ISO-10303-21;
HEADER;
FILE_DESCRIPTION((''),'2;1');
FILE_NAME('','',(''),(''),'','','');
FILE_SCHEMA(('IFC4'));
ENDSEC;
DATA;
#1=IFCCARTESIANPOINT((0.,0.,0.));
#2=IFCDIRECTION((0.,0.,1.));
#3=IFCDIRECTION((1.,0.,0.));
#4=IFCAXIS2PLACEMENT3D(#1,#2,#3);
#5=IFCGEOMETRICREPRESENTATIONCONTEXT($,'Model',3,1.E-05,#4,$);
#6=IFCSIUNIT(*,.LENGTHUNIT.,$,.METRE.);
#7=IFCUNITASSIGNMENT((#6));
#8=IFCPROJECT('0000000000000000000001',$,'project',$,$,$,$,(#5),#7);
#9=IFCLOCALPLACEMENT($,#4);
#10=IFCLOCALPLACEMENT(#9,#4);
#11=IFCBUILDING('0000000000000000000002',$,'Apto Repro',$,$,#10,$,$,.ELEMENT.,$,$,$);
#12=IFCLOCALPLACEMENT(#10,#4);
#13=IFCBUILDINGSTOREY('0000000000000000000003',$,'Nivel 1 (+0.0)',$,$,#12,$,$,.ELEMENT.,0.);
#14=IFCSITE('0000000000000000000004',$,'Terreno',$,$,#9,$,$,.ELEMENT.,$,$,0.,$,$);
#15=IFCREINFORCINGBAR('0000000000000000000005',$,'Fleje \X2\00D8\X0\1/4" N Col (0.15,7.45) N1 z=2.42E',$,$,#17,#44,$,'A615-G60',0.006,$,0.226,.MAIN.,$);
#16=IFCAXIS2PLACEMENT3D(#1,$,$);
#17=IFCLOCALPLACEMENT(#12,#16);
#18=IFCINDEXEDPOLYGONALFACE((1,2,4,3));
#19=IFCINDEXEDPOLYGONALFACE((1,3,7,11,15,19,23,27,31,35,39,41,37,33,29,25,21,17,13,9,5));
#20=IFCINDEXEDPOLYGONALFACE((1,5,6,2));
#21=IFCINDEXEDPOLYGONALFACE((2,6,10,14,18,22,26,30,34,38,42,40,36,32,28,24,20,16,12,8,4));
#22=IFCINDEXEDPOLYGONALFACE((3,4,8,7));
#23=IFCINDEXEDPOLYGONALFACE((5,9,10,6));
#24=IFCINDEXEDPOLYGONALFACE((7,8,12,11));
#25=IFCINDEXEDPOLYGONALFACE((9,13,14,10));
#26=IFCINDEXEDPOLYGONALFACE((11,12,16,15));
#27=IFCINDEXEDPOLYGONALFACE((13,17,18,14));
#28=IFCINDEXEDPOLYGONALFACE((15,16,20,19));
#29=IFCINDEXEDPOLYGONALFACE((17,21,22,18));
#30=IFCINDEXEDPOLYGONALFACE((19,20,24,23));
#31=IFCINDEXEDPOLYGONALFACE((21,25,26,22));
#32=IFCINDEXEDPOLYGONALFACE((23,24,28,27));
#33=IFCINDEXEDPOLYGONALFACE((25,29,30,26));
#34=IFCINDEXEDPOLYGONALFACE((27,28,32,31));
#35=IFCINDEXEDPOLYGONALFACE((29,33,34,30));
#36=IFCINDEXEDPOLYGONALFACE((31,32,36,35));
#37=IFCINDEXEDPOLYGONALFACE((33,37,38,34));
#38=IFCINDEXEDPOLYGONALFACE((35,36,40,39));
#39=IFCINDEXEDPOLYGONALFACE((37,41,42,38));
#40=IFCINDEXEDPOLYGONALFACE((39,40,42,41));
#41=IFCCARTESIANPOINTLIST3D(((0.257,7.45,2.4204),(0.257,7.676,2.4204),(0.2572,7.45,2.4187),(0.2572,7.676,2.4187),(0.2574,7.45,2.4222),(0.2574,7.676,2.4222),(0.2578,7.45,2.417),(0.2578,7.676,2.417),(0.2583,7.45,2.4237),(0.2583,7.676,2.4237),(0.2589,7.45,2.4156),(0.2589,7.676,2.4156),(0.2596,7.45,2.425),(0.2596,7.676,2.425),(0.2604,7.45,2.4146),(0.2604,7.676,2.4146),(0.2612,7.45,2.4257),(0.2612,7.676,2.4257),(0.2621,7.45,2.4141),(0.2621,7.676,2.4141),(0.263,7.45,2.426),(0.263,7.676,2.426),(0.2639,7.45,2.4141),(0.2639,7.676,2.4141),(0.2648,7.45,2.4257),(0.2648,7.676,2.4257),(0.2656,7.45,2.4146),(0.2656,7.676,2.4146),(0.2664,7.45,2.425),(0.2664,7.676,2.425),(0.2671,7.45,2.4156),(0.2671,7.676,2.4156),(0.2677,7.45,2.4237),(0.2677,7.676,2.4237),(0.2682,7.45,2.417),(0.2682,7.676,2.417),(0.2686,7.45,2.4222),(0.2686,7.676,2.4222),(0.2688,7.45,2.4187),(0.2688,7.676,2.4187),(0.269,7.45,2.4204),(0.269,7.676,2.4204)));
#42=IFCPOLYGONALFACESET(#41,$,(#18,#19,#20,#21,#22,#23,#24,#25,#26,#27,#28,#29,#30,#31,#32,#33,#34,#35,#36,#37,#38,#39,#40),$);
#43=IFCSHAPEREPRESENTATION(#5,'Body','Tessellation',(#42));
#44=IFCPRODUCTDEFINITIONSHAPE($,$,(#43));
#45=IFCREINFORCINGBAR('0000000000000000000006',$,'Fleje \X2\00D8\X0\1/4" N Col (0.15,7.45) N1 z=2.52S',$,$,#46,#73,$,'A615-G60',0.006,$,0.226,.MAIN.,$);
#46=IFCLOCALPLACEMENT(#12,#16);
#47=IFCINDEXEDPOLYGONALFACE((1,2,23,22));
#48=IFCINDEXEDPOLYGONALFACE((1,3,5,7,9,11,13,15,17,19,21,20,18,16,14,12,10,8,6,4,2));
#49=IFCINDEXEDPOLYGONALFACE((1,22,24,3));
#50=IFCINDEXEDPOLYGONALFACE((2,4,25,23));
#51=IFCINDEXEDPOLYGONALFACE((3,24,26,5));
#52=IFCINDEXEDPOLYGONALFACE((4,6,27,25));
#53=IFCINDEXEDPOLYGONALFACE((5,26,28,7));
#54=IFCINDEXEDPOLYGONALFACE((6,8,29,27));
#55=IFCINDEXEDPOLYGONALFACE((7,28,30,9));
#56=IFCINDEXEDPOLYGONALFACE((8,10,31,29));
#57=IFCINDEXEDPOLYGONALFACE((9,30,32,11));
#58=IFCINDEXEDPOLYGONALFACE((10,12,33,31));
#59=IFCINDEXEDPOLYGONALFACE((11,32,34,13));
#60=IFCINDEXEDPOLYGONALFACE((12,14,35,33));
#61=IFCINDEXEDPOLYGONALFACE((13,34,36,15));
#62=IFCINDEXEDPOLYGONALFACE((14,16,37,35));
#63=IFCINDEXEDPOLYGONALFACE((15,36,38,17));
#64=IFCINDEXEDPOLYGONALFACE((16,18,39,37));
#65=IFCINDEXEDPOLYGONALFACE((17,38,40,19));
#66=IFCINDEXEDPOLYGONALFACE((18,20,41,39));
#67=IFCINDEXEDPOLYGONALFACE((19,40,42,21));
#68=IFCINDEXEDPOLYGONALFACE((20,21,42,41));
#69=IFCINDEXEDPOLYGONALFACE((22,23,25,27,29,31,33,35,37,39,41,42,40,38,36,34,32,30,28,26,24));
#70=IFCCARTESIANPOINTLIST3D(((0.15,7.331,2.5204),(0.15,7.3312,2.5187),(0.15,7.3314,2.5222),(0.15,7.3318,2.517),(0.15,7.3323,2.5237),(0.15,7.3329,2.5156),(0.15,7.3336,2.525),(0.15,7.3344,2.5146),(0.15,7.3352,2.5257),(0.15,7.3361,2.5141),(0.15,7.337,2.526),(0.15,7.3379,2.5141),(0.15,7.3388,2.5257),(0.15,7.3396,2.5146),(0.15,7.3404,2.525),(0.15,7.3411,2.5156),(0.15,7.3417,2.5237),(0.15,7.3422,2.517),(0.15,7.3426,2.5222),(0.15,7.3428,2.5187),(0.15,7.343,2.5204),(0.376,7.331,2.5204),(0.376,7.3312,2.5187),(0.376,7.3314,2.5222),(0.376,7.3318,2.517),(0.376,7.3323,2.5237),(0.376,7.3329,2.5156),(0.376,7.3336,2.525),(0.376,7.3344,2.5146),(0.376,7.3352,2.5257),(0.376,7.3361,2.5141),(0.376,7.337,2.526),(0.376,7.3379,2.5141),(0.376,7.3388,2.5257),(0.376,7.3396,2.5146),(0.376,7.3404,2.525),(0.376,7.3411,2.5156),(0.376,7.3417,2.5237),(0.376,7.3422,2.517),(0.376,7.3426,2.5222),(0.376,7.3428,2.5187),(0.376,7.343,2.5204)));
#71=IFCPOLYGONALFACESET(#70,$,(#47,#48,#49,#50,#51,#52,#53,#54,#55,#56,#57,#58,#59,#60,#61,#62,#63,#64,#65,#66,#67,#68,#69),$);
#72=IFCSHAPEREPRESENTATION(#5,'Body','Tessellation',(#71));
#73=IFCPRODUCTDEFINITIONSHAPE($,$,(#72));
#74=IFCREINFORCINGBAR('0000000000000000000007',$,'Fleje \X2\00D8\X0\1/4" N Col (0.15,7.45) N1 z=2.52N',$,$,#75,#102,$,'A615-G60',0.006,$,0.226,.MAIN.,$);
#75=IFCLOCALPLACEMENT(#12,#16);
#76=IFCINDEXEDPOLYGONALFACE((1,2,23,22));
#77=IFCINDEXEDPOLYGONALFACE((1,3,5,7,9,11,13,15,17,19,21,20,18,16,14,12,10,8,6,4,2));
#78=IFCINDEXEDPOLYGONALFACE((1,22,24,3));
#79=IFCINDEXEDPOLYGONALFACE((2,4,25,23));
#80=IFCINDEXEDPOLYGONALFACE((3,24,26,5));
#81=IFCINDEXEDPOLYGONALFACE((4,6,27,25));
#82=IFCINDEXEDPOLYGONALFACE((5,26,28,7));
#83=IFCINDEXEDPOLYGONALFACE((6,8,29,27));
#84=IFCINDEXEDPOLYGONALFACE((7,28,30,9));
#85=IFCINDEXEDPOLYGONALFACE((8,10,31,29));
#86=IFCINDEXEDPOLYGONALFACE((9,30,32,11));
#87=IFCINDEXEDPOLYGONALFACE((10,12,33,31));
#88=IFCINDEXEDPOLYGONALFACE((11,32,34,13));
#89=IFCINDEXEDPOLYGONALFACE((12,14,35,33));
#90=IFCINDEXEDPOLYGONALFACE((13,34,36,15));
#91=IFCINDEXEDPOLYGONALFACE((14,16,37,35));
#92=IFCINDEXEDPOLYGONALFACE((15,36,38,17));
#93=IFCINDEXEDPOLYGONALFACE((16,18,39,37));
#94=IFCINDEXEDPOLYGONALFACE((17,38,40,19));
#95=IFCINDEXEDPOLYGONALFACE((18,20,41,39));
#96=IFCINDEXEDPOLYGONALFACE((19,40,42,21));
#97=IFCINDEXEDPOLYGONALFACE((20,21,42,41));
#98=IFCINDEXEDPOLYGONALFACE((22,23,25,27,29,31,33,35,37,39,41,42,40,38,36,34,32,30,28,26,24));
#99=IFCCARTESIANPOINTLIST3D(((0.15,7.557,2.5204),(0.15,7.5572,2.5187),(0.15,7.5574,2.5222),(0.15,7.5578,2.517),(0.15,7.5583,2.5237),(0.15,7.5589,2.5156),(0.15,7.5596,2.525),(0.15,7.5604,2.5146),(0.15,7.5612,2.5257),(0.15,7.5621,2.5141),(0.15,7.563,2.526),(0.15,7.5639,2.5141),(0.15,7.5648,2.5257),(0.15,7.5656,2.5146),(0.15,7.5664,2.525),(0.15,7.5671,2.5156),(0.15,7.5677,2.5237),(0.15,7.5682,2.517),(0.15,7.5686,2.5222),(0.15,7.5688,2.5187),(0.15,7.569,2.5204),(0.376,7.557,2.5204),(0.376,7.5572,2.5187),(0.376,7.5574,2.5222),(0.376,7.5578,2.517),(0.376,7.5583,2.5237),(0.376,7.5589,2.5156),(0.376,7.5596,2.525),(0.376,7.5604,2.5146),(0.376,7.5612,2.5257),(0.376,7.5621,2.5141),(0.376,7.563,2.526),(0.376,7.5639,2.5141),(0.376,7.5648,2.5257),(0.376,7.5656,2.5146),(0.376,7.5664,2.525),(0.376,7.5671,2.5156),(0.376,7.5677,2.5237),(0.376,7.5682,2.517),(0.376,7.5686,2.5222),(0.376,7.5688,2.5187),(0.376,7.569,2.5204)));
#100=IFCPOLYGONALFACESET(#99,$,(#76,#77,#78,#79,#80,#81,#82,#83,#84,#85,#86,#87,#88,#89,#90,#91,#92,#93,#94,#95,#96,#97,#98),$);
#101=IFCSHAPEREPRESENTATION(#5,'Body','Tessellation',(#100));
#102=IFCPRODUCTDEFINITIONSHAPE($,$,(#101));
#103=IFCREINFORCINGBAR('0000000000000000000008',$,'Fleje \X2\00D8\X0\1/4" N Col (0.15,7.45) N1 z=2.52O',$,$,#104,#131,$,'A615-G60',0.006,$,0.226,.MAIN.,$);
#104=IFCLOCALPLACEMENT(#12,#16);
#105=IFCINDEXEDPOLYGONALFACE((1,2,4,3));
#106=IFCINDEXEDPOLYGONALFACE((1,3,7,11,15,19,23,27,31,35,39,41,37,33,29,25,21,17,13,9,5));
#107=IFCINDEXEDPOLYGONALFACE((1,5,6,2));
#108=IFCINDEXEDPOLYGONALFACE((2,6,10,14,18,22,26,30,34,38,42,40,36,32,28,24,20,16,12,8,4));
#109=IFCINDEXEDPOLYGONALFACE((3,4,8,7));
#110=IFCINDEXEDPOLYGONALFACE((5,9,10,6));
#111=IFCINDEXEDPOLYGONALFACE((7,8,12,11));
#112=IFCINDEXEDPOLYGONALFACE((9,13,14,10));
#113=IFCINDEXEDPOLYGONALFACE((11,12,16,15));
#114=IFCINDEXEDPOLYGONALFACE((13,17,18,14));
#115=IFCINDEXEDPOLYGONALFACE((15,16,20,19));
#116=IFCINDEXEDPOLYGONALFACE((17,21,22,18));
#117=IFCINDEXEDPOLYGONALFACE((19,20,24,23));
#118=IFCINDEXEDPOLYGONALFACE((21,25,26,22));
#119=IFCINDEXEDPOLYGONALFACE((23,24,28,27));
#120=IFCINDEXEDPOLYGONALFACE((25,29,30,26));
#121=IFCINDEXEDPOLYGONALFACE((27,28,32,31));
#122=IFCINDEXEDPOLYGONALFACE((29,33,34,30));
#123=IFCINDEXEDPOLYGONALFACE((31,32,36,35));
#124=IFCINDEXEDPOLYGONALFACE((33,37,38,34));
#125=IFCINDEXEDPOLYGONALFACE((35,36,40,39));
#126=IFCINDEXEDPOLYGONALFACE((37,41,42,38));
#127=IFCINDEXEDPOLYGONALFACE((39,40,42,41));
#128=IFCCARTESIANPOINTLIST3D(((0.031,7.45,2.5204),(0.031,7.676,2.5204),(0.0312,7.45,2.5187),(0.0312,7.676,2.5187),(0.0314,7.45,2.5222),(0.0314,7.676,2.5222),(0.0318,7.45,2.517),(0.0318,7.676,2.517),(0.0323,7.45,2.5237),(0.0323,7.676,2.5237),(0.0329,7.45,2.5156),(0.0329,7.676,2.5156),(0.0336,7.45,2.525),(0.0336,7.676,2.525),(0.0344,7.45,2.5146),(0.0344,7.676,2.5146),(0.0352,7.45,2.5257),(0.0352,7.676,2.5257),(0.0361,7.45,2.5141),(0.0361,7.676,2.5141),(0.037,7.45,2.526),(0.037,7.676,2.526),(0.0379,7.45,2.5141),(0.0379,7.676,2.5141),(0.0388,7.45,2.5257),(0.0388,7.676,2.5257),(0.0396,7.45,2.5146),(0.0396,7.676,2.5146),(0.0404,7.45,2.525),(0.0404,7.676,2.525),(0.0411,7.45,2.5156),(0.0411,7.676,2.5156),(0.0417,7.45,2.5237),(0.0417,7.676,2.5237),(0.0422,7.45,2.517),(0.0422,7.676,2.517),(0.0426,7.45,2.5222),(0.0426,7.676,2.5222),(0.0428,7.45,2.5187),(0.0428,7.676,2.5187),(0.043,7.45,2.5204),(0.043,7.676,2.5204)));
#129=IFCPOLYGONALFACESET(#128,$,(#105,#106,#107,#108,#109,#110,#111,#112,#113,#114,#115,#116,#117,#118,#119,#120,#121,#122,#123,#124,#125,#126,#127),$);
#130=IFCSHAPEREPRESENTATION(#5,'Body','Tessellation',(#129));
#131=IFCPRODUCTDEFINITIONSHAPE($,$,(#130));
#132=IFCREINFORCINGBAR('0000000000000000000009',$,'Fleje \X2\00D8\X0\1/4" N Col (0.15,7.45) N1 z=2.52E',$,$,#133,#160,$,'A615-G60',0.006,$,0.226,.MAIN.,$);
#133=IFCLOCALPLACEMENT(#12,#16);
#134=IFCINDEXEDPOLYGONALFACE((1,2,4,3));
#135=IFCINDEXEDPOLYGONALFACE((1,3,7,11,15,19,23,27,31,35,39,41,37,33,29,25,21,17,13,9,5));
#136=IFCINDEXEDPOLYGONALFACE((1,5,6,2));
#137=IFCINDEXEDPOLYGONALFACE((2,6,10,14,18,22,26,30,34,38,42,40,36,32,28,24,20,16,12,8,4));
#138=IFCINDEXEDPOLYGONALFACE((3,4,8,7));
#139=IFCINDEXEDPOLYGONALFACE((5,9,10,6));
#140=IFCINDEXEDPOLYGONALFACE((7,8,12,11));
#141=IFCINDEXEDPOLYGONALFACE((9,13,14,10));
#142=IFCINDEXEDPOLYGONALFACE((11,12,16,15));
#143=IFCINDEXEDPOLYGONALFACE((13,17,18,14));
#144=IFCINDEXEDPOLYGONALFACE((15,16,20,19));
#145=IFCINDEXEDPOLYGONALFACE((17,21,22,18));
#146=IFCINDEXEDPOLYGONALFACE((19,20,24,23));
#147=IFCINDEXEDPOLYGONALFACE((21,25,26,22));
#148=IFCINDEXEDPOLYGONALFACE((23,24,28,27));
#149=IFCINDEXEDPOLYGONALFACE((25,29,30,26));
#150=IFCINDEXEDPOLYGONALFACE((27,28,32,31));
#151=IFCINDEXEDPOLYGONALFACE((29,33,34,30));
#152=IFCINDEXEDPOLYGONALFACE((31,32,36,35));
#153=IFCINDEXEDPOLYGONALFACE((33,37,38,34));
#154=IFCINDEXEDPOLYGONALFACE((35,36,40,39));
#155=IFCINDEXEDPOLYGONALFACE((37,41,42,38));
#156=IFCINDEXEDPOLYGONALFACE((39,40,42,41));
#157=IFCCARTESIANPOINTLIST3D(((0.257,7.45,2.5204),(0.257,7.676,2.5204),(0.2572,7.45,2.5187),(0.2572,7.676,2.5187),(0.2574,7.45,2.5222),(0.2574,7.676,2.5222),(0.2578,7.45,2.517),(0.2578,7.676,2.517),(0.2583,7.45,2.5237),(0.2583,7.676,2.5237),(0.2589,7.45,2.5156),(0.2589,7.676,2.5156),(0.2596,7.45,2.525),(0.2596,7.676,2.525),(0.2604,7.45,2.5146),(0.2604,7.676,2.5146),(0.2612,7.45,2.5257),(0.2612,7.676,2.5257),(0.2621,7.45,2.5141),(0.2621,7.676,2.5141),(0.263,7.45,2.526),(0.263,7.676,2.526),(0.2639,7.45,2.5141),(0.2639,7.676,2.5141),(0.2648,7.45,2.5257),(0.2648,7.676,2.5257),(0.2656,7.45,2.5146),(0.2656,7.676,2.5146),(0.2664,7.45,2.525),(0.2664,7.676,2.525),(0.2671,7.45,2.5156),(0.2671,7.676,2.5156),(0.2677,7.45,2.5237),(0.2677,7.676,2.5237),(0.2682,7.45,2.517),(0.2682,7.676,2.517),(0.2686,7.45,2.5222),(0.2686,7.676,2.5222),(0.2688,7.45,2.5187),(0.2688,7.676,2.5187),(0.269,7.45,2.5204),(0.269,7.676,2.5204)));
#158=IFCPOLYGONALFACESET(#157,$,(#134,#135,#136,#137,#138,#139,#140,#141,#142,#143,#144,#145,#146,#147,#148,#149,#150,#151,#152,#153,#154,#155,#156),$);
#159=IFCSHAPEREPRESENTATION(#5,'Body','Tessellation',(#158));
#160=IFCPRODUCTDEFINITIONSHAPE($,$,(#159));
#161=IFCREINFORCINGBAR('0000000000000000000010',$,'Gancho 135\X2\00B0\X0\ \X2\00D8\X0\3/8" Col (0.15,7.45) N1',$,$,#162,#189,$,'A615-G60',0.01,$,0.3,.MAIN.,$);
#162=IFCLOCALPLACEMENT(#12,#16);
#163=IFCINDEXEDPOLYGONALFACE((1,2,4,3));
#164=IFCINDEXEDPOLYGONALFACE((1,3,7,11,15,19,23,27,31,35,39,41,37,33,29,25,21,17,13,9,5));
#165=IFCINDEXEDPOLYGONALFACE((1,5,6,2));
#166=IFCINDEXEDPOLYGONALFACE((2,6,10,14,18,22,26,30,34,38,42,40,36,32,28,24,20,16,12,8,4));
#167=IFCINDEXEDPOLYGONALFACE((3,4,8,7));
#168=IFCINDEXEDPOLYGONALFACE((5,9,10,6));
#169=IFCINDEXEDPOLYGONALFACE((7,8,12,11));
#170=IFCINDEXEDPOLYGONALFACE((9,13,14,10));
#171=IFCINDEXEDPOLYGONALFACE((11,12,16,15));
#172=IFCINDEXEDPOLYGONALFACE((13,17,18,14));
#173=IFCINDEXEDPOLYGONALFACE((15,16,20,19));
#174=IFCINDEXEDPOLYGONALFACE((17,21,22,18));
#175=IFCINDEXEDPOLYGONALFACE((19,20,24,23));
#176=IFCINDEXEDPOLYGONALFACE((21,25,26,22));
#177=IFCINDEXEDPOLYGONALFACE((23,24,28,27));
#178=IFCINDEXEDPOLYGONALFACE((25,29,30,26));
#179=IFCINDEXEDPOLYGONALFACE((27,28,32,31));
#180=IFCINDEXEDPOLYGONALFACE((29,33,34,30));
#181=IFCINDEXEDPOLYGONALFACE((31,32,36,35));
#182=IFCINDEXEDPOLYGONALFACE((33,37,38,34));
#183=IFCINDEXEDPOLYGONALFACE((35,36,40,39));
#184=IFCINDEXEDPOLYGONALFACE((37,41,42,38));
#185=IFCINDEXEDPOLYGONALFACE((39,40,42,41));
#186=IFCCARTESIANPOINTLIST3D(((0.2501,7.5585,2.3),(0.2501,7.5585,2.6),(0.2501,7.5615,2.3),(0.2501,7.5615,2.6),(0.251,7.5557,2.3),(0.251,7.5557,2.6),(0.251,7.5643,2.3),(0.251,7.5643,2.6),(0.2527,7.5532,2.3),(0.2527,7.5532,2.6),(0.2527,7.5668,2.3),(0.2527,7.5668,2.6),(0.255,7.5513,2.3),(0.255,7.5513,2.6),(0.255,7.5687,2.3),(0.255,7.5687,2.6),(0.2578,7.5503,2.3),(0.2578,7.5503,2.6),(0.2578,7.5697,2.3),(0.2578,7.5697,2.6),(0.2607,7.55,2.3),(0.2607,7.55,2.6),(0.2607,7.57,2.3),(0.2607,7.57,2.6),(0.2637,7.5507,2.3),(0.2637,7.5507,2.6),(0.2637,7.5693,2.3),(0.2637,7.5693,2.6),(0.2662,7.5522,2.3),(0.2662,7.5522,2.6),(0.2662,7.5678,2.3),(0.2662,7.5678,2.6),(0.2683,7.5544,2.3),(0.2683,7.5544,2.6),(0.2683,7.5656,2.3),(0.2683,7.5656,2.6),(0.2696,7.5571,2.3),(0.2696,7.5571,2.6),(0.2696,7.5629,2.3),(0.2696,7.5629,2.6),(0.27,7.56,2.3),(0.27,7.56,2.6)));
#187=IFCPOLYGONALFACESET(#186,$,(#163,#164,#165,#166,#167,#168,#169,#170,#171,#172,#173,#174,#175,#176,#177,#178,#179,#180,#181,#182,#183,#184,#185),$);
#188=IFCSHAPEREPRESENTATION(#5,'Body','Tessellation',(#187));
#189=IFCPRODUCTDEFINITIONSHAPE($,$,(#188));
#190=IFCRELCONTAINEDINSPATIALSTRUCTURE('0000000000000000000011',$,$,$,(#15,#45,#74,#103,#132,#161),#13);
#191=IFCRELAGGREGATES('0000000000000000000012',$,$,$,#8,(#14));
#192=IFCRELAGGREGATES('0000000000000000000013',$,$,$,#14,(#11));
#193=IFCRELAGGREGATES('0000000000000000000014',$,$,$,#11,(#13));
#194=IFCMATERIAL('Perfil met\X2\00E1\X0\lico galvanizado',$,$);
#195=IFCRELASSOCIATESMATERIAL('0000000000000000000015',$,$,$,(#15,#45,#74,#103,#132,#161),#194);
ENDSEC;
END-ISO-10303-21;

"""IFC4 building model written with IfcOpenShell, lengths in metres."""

from ifc_helpers import new_model, si_unit, frame, origin_with_axes, origin_2d_with_axis, place, context, project, spatial, circle, extrude, material, element, save


model = new_model("IFC4")

# Units and contexts
model_context = context("Model", 3, precision=1e-05, world=origin_with_axes())
ifc_project = project(units=[si_unit("LENGTHUNIT", "METRE")], contexts=[model_context])

# Site, building, storey
site_placement = place(None, origin_with_axes())
site = spatial("IfcSite", under=ifc_project, at=site_placement, Name="Terreno", CompositionType="ELEMENT", RefElevation=0.0)
building_placement = place(site_placement, origin_with_axes())
building = spatial("IfcBuilding", under=site, at=building_placement, Name="Apto Repro", CompositionType="ELEMENT")
storey_placement = place(building_placement, origin_with_axes())
storey = spatial("IfcBuildingStorey", under=building, at=storey_placement, Name="Nivel 1 (+0.0)", CompositionType="ELEMENT", Elevation=0.0)

# Reinforcing bars
ifc_material = material(Name="Perfil metálico galvanizado")
reinforcing_bar_1_placement = place(storey_placement, origin_with_axes())
element("IfcReinforcingBar", 1, at=reinforcing_bar_1_placement, inside=storey, material=ifc_material, Name="Fleje Ø1/4\" N Col (0.15,7.45) N1 z=2.42E", SteelGrade="A615-G60", BarLength=0.226, NominalDiameter=0.006, PredefinedType="MAIN", context=model_context, shape_type="SweptSolid", body=[
    extrude(circle(Radius=0.006, at=origin_2d_with_axis()), frame((0.263, 7.45, 2.42), z_axis=(0.0, 1.0, 0.0), x_axis=(0.0, 0.0, 1.0)), (0.0, 0.0, 1.0), 0.226),
])
reinforcing_bar_2_placement = place(storey_placement, origin_with_axes())
element("IfcReinforcingBar", 2, at=reinforcing_bar_2_placement, inside=storey, material=ifc_material, Name="Fleje Ø1/4\" N Col (0.15,7.45) N1 z=2.52S", SteelGrade="A615-G60", BarLength=0.226, NominalDiameter=0.006, PredefinedType="MAIN", context=model_context, shape_type="SweptSolid", body=[
    extrude(circle(Radius=0.006, at=origin_2d_with_axis()), frame((0.15, 7.337, 2.52), z_axis=(1.0, 0.0, 0.0), x_axis=(0.0, 0.0, 1.0)), (0.0, 0.0, 1.0), 0.226),
])
reinforcing_bar_3_placement = place(storey_placement, origin_with_axes())
element("IfcReinforcingBar", 3, at=reinforcing_bar_3_placement, inside=storey, material=ifc_material, Name="Fleje Ø1/4\" N Col (0.15,7.45) N1 z=2.52N", SteelGrade="A615-G60", BarLength=0.226, NominalDiameter=0.006, PredefinedType="MAIN", context=model_context, shape_type="SweptSolid", body=[
    extrude(circle(Radius=0.006, at=origin_2d_with_axis()), frame((0.15, 7.563, 2.52), z_axis=(1.0, 0.0, 0.0), x_axis=(0.0, 0.0, 1.0)), (0.0, 0.0, 1.0), 0.226),
])
reinforcing_bar_4_placement = place(storey_placement, origin_with_axes())
element("IfcReinforcingBar", 4, at=reinforcing_bar_4_placement, inside=storey, material=ifc_material, Name="Fleje Ø1/4\" N Col (0.15,7.45) N1 z=2.52O", SteelGrade="A615-G60", BarLength=0.226, NominalDiameter=0.006, PredefinedType="MAIN", context=model_context, shape_type="SweptSolid", body=[
    extrude(circle(Radius=0.006, at=origin_2d_with_axis()), frame((0.037, 7.45, 2.52), z_axis=(0.0, 1.0, 0.0), x_axis=(0.0, 0.0, 1.0)), (0.0, 0.0, 1.0), 0.226),
])
reinforcing_bar_5_placement = place(storey_placement, origin_with_axes())
element("IfcReinforcingBar", 5, at=reinforcing_bar_5_placement, inside=storey, material=ifc_material, Name="Fleje Ø1/4\" N Col (0.15,7.45) N1 z=2.52E", SteelGrade="A615-G60", BarLength=0.226, NominalDiameter=0.006, PredefinedType="MAIN", context=model_context, shape_type="SweptSolid", body=[
    extrude(circle(Radius=0.006, at=origin_2d_with_axis()), frame((0.263, 7.45, 2.52), z_axis=(0.0, 1.0, 0.0), x_axis=(0.0, 0.0, 1.0)), (0.0, 0.0, 1.0), 0.226),
])
reinforcing_bar_6_placement = place(storey_placement, origin_with_axes())
element("IfcReinforcingBar", 6, at=reinforcing_bar_6_placement, inside=storey, material=ifc_material, Name="Gancho 135° Ø3/8\" Col (0.15,7.45) N1", SteelGrade="A615-G60", BarLength=0.3, NominalDiameter=0.01, PredefinedType="MAIN", context=model_context, shape_type="SweptSolid", body=[
    extrude(circle(Radius=0.01, at=origin_2d_with_axis()), frame((0.26, 7.56, 2.3), z_axis=(0.0, 0.0, 1.0), x_axis=(1.0, 0.0, 0.0)), (0.0, 0.0, 1.0), 0.3),
])

save(model, "model.ifc")
